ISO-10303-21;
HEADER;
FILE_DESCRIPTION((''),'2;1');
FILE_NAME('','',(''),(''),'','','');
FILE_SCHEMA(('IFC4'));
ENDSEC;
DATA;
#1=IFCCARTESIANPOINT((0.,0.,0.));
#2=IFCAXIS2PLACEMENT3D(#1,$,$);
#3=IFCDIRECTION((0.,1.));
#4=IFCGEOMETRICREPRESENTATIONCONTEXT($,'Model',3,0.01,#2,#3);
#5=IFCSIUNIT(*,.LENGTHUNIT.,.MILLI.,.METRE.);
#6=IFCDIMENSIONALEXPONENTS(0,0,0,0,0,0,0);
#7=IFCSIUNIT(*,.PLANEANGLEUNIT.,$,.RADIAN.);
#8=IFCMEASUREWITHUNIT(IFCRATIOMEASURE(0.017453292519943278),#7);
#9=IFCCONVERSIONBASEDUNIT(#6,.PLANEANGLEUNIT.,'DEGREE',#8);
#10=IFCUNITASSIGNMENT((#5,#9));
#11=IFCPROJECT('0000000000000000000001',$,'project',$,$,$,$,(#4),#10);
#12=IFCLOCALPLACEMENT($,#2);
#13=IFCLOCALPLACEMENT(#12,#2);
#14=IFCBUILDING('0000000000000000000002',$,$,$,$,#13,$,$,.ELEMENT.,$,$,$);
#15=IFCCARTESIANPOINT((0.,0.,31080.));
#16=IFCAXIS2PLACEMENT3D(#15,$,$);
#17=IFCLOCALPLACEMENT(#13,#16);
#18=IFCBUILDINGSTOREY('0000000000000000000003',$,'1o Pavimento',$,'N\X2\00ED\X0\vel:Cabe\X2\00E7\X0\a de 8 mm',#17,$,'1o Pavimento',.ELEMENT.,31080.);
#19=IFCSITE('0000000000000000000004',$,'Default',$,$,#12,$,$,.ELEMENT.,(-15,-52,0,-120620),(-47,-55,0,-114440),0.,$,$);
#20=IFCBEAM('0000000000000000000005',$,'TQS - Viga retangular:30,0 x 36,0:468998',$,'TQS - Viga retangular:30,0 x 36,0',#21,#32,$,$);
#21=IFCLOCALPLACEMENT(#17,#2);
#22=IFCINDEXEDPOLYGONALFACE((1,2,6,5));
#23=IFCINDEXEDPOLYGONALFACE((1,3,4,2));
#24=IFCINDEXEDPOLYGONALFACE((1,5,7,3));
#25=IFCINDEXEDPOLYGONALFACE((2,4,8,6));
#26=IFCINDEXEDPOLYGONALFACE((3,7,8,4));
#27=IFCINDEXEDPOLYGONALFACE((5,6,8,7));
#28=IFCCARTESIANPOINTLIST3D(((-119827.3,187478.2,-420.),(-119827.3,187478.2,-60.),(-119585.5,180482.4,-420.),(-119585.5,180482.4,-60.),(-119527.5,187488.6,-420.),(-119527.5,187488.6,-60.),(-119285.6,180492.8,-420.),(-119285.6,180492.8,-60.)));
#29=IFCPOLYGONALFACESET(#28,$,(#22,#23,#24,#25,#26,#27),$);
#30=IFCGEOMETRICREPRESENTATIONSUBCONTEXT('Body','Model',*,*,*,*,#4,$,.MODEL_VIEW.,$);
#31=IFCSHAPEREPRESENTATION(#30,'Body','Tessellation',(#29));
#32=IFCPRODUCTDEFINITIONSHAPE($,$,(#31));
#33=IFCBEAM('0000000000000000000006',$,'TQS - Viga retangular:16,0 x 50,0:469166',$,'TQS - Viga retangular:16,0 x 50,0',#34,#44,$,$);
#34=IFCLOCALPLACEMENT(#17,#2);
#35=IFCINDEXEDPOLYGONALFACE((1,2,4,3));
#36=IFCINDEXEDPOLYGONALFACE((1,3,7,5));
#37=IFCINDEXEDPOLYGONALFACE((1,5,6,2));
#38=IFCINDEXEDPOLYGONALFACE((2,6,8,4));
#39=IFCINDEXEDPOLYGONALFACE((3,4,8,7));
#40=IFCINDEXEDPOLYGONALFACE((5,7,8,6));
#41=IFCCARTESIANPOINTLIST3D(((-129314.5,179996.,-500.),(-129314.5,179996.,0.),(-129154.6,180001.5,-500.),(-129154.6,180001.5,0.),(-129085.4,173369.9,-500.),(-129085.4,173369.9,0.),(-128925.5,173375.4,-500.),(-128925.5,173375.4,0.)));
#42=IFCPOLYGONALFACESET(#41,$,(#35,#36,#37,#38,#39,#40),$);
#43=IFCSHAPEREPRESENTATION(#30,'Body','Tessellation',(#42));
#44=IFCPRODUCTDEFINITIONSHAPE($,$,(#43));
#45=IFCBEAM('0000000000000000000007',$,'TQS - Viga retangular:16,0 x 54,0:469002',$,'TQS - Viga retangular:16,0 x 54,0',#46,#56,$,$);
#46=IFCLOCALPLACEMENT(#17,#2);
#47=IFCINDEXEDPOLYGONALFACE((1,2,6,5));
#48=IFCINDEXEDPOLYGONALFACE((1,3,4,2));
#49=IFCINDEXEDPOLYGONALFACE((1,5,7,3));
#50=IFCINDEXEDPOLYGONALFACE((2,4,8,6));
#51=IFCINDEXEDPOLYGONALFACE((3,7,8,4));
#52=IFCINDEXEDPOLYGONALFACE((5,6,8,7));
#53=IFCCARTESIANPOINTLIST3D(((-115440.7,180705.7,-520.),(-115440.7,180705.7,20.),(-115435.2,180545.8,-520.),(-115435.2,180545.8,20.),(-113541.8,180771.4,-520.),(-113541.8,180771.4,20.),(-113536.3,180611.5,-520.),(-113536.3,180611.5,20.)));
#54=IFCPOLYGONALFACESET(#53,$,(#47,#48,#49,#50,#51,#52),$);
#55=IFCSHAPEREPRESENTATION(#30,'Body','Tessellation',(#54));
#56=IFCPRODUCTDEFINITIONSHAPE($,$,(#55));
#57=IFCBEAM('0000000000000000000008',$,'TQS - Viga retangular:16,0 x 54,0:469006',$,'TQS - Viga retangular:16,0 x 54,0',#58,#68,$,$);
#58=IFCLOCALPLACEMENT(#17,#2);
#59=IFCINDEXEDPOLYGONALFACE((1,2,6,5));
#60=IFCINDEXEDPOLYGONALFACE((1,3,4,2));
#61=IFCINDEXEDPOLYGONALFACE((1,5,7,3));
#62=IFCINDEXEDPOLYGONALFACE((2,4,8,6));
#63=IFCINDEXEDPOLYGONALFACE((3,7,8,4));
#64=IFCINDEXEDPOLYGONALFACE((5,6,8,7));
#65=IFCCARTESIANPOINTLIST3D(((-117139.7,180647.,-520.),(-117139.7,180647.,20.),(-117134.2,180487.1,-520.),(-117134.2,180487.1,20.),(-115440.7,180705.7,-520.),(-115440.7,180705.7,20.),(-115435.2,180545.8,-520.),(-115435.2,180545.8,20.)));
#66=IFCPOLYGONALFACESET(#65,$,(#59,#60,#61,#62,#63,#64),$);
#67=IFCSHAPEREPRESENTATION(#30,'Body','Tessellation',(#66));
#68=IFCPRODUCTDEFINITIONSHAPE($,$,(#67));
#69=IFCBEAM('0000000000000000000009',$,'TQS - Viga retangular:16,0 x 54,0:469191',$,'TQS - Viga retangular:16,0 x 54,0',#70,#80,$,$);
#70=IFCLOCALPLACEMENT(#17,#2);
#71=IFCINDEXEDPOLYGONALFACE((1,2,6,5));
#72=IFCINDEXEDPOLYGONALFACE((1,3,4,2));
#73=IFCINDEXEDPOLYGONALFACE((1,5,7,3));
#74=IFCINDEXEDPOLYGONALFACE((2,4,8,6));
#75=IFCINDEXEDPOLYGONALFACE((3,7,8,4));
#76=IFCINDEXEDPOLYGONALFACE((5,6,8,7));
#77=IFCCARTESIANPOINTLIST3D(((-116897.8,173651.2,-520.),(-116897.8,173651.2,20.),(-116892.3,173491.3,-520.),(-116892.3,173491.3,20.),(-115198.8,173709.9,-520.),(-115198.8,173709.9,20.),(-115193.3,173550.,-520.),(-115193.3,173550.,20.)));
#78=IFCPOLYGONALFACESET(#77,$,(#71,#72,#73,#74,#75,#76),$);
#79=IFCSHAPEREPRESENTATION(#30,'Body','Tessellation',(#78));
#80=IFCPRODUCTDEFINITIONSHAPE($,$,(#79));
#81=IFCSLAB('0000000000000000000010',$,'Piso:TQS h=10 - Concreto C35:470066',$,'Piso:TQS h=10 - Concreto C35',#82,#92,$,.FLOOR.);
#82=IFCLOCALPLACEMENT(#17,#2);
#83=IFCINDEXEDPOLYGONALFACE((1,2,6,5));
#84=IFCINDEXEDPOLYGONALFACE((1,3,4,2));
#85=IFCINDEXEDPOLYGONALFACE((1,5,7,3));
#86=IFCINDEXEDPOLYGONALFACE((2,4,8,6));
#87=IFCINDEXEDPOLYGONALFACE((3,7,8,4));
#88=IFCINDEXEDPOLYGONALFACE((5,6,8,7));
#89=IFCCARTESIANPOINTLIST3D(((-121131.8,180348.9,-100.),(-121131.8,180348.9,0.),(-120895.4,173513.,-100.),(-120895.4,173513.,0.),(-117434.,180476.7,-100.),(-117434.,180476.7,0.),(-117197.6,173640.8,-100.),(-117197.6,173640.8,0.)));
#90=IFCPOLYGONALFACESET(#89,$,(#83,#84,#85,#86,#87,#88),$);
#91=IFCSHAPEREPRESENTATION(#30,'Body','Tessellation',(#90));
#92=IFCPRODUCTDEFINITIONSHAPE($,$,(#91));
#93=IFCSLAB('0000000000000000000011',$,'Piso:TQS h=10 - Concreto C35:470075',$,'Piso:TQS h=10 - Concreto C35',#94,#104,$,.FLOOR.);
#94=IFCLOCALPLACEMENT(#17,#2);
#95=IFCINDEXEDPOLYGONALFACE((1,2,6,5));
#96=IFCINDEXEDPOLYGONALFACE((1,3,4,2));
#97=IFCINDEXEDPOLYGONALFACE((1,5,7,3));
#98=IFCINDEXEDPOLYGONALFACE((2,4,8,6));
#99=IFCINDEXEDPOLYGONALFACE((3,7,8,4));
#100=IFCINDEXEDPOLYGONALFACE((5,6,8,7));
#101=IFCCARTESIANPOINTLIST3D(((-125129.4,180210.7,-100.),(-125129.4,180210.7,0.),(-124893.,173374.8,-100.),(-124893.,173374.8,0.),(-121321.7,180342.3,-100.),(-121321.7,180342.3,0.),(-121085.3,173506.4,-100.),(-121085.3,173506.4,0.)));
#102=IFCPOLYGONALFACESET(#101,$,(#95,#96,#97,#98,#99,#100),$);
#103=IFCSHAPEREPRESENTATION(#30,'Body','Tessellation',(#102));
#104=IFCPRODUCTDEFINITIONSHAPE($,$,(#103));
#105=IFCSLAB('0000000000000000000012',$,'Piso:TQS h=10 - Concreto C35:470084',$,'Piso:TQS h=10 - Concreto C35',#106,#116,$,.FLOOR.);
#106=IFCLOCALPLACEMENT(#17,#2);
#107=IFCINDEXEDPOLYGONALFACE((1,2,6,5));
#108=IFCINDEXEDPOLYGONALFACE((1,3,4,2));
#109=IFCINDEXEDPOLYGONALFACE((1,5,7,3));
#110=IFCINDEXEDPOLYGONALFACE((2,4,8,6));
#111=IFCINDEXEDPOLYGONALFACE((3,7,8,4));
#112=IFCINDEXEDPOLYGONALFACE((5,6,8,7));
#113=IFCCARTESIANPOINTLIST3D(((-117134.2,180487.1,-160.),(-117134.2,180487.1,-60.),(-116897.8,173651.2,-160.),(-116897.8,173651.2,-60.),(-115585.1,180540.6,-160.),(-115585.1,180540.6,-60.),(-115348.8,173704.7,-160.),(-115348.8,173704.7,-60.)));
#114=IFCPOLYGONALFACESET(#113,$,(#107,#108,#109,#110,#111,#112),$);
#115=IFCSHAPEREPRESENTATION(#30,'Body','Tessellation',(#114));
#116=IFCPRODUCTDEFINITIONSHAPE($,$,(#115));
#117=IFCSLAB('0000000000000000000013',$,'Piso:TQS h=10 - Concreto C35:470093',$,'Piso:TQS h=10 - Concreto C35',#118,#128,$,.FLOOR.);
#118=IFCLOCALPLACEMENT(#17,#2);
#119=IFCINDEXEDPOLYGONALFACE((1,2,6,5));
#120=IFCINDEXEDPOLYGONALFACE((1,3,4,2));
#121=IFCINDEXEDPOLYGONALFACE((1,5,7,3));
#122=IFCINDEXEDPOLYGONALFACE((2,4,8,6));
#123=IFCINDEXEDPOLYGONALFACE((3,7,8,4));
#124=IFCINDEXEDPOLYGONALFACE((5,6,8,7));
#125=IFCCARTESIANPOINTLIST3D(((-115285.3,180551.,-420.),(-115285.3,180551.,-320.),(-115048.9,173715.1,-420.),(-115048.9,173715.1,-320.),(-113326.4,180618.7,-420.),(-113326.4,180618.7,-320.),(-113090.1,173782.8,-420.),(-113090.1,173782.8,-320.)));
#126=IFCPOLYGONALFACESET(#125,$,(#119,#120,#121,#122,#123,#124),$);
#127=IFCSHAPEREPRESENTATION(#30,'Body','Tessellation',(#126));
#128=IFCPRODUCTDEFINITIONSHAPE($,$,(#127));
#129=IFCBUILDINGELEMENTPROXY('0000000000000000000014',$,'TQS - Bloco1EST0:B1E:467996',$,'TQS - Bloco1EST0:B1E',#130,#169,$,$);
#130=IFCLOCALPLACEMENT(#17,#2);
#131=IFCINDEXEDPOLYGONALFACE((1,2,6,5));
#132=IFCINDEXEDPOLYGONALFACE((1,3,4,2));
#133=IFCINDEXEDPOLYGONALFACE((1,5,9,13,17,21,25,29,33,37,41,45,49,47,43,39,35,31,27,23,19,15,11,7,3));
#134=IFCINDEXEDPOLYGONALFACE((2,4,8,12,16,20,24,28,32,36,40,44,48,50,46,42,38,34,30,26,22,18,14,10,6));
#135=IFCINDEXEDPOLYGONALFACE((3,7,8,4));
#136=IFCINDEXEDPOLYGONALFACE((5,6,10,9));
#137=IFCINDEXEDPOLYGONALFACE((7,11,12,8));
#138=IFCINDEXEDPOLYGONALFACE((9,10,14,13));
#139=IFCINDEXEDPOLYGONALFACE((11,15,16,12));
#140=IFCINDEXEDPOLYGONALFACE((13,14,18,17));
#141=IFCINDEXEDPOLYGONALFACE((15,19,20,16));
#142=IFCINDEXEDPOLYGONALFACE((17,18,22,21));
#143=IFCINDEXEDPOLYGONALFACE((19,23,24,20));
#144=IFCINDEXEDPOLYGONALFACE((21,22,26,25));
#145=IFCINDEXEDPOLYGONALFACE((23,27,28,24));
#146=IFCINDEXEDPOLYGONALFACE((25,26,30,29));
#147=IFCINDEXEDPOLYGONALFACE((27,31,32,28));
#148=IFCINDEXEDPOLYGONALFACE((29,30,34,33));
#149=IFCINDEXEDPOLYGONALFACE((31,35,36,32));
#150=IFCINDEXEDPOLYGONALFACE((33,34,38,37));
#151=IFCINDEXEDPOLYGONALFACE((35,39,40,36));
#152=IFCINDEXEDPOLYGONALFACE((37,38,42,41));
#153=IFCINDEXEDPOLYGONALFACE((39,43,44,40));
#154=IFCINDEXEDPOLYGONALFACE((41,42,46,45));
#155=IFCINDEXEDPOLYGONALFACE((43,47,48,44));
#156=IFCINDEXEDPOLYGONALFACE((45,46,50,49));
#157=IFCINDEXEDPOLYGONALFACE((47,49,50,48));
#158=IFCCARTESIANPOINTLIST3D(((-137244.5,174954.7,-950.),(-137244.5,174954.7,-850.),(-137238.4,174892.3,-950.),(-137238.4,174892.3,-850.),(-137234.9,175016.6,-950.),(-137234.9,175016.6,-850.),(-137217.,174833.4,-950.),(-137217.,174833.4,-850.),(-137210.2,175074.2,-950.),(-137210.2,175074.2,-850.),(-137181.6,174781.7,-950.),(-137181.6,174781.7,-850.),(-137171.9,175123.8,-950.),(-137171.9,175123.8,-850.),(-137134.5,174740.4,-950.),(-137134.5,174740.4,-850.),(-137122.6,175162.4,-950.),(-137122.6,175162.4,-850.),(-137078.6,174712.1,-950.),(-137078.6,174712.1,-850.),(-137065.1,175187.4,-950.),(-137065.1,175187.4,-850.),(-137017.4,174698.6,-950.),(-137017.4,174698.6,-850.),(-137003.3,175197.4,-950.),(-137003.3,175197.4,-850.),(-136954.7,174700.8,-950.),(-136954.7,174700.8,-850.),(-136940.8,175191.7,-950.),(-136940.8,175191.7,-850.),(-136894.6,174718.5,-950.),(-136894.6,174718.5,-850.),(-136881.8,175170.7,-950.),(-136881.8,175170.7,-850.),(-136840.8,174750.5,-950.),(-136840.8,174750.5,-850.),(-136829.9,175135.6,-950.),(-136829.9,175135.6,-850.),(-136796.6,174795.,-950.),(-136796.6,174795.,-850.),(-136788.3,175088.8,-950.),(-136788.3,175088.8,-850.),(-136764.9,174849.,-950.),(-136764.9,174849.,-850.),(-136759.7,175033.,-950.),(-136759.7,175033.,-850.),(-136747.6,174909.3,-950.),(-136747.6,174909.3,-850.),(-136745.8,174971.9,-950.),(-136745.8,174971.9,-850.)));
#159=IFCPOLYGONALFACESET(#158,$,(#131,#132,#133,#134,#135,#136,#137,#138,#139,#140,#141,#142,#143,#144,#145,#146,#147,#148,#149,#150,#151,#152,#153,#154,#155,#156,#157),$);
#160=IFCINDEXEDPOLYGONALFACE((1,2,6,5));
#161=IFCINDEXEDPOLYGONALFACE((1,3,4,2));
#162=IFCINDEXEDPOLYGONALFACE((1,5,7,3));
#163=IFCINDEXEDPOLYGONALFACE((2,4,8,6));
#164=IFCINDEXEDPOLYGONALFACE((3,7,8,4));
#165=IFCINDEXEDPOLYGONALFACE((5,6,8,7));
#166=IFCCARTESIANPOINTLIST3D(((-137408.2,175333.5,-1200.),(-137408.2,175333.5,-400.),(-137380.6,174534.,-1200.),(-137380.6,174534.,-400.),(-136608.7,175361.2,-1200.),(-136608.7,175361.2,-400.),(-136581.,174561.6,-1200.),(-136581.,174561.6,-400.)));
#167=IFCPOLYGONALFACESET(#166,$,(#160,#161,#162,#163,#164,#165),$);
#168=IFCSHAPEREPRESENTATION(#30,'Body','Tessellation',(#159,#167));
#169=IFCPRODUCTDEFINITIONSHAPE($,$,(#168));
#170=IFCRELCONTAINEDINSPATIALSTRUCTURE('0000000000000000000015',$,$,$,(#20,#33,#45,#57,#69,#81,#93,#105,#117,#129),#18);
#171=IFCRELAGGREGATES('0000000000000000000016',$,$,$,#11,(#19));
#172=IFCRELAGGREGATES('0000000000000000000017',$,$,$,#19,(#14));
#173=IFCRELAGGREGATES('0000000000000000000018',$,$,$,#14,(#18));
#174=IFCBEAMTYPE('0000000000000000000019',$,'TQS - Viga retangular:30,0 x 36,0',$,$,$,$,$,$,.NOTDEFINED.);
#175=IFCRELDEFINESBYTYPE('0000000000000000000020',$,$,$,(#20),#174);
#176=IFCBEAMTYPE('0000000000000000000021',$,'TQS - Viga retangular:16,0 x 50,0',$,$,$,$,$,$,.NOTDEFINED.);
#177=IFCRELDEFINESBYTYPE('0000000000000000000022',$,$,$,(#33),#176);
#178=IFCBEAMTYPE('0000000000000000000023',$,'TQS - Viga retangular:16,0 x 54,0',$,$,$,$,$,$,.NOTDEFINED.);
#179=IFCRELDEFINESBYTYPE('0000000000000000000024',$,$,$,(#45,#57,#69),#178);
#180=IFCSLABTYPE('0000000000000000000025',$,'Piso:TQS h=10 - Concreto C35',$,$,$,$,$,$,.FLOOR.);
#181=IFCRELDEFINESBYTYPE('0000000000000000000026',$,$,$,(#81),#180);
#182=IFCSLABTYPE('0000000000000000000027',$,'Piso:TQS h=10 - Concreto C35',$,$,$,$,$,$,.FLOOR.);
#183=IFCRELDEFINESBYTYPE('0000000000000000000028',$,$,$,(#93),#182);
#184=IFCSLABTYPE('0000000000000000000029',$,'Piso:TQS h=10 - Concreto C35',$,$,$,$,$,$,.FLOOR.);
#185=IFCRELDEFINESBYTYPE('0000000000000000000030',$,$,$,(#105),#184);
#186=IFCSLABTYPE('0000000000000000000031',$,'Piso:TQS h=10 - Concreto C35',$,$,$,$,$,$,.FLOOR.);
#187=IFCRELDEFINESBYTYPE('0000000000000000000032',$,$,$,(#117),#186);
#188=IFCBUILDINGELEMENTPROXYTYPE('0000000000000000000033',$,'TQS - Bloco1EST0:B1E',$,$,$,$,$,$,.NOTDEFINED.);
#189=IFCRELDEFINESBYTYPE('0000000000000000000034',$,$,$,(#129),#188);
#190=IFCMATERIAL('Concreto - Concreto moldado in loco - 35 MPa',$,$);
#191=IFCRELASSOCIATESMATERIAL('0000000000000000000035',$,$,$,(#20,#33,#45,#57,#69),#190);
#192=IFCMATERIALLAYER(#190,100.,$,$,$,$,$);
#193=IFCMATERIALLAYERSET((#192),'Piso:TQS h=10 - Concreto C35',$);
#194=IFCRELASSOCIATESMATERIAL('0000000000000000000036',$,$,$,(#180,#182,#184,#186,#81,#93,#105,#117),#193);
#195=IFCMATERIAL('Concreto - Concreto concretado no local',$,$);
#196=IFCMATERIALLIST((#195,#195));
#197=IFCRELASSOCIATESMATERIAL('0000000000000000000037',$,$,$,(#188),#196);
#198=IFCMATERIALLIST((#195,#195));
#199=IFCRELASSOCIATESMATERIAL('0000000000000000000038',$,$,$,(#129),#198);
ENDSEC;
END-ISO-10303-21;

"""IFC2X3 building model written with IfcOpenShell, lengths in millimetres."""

from ifc_helpers import new_model, entity, si_unit, converted_unit, direction, frame, frame_2d, origin, origin_2d_with_axis, place, context, subcontext, project, spatial, rectangle, circle, extrude, source, transform, mapped, material, material_list, layer, layer_set, layer_usage, type_object, type_shapes, element, save


model = new_model("IFC2X3")

# Units and contexts
model_context = context("Model", 3, precision=0.01, world=origin(), true_north=direction((0.0, 1.0)))
body_context = subcontext(model_context, "Body", "Model", "MODEL_VIEW")
ifc_project = project(units=[si_unit("LENGTHUNIT", "METRE", prefix="MILLI"), converted_unit("PLANEANGLEUNIT", "DEGREE", entity("IfcRatioMeasure", 0.017453292519943278), si_unit("PLANEANGLEUNIT", "RADIAN"), dimensions=[0, 0, 0, 0, 0, 0, 0])], contexts=[model_context])

# Site, building, storey
site_placement = place(None, origin())
site = spatial("IfcSite", under=ifc_project, at=site_placement, Name="Default", CompositionType="ELEMENT", RefLatitude=(-15, -52, 0, -120620), RefLongitude=(-47, -55, 0, -114440), RefElevation=0.0)
building_placement = place(site_placement, origin())
building = spatial("IfcBuilding", under=site, at=building_placement, CompositionType="ELEMENT")
storey_placement = place(building_placement, frame((0.0, 0.0, 31080.0)))
storey = spatial("IfcBuildingStorey", under=building, at=storey_placement, Name="1o Pavimento", ObjectType="Nível:Cabeça de 8 mm", LongName="1o Pavimento", CompositionType="ELEMENT", Elevation=31080.0)

# Beams
ifc_material_1 = material(Name="Concreto - Concreto moldado in loco - 35 MPa")
beam_type_1 = type_object("IfcBeamType", Name="TQS - Viga retangular:30,0 x 36,0", PredefinedType="NOTDEFINED")
beam_1_placement = place(storey_placement, frame((-119435.5, 180487.6, -60.0), z_axis=(0.0, 0.0, 1.0), x_axis=(-0.034551, 0.999403, 0.0)))
element("IfcBeam", 1, at=beam_1_placement, inside=storey, type_object=beam_type_1, material=ifc_material_1, Name="TQS - Viga retangular:30,0 x 36,0:468998", ObjectType="TQS - Viga retangular:30,0 x 36,0", context=body_context, shape_type="SweptSolid", body=[
    extrude(rectangle(XDim=360.0, YDim=300.0, at=frame_2d((0.0, 0.0), x_axis=(1.0, 0.0))), frame((0.0, 0.0, -180.0), z_axis=(1.0, 0.0, 0.0), x_axis=(0.0, 0.0, -1.0)), (0.0, 0.0, 1.0), 7000.0),
])
beam_type_2 = type_object("IfcBeamType", Name="TQS - Viga retangular:16,0 x 50,0", PredefinedType="NOTDEFINED")
beam_2_placement = place(storey_placement, frame((-129005.4, 173372.7, 0.0), z_axis=(0.0, 0.0, 1.0), x_axis=(-0.034551, 0.999403, 0.0)))
element("IfcBeam", 2, at=beam_2_placement, inside=storey, type_object=beam_type_2, material=ifc_material_1, Name="TQS - Viga retangular:16,0 x 50,0:469166", ObjectType="TQS - Viga retangular:16,0 x 50,0", context=body_context, shape_type="SweptSolid", body=[
    extrude(rectangle(XDim=500.0, YDim=160.0, at=frame_2d((0.0, 0.0), x_axis=(1.0, 0.0))), frame((0.0, 0.0, -250.0), z_axis=(1.0, 0.0, 0.0), x_axis=(0.0, 0.0, -1.0)), (0.0, 0.0, 1.0), 6630.0),
])
beam_type_3 = type_object("IfcBeamType", Name="TQS - Viga retangular:16,0 x 54,0", PredefinedType="NOTDEFINED")
beam_3_placement = place(storey_placement, frame((-113539.1, 180691.4, 20.0), z_axis=(0.0, 0.0, 1.0), x_axis=(-0.999403, -0.034551, 0.0)))
element("IfcBeam", 3, at=beam_3_placement, inside=storey, type_object=beam_type_3, material=ifc_material_1, Name="TQS - Viga retangular:16,0 x 54,0:469002", ObjectType="TQS - Viga retangular:16,0 x 54,0", context=body_context, shape_type="SweptSolid", body=[
    extrude(rectangle(XDim=540.0, YDim=160.0, at=origin_2d_with_axis()), frame((0.0, 0.0, -270.0), z_axis=(1.0, 0.0, 0.0), x_axis=(0.0, 0.0, -1.0)), (0.0, 0.0, 1.0), 1900.0),
])
beam_4_placement = place(storey_placement, frame((-115437.9, 180625.8, 20.0), z_axis=(0.0, 0.0, 1.0), x_axis=(-0.999403, -0.034551, 0.0)))
element("IfcBeam", 4, at=beam_4_placement, inside=storey, type_object=beam_type_3, material=ifc_material_1, Name="TQS - Viga retangular:16,0 x 54,0:469006", ObjectType="TQS - Viga retangular:16,0 x 54,0", context=body_context, shape_type="SweptSolid", body=[
    extrude(rectangle(XDim=540.0, YDim=160.0, at=frame_2d((0.0, 0.0), x_axis=(1.0, 0.0))), frame((0.0, 0.0, -270.0), z_axis=(1.0, 0.0, 0.0), x_axis=(0.0, 0.0, -1.0)), (0.0, 0.0, 1.0), 1700.0),
])
beam_5_placement = place(storey_placement, frame((-115196.1, 173630.0, 20.0), z_axis=(0.0, 0.0, 1.0), x_axis=(-0.999403, -0.034551, 0.0)))
element("IfcBeam", 5, at=beam_5_placement, inside=storey, type_object=beam_type_3, material=ifc_material_1, Name="TQS - Viga retangular:16,0 x 54,0:469191", ObjectType="TQS - Viga retangular:16,0 x 54,0", context=body_context, shape_type="SweptSolid", body=[
    extrude(rectangle(XDim=540.0, YDim=160.0, at=frame_2d((0.0, 0.0), x_axis=(1.0, 0.0))), frame((0.0, 0.0, -270.0), z_axis=(1.0, 0.0, 0.0), x_axis=(0.0, 0.0, -1.0)), (0.0, 0.0, 1.0), 1700.0),
])

# Slabs
ifc_layer = layer(ifc_material_1, 100.0)
ifc_layer_set = layer_set([ifc_layer], Name="Piso:TQS h=10 - Concreto C35")
ifc_layer_usage_1 = layer_usage(ifc_layer_set, "AXIS3", "POSITIVE", 0.0)
slab_type_1 = type_object("IfcSlabType", Name="Piso:TQS h=10 - Concreto C35", PredefinedType="FLOOR", material=ifc_layer_set)
slab_1_placement = place(storey_placement, origin())
element("IfcSlab", 6, at=slab_1_placement, inside=storey, type_object=slab_type_1, material=ifc_layer_usage_1, Name="Piso:TQS h=10 - Concreto C35:470066", ObjectType="Piso:TQS h=10 - Concreto C35", PredefinedType="FLOOR", context=body_context, shape_type="SweptSolid", body=[
    extrude(rectangle(XDim=6840.0, YDim=3700.0, at=frame_2d((0.0, 0.0), x_axis=(1.0, 0.0))), frame((-119164.7, 176994.8, 0.0), z_axis=(0.0, 0.0, -1.0), x_axis=(0.034551, -0.999403, 0.0)), (0.0, 0.0, 1.0), 100.0),
])
ifc_layer_usage_2 = layer_usage(ifc_layer_set, "AXIS3", "POSITIVE", 0.0)
slab_type_2 = type_object("IfcSlabType", Name="Piso:TQS h=10 - Concreto C35", PredefinedType="FLOOR", material=ifc_layer_set)
slab_2_placement = place(storey_placement, origin())
element("IfcSlab", 7, at=slab_2_placement, inside=storey, type_object=slab_type_2, material=ifc_layer_usage_2, Name="Piso:TQS h=10 - Concreto C35:470075", ObjectType="Piso:TQS h=10 - Concreto C35", PredefinedType="FLOOR", context=body_context, shape_type="SweptSolid", body=[
    extrude(rectangle(XDim=6840.0, YDim=3810.0, at=frame_2d((0.0, 0.0), x_axis=(1.0, 0.0))), frame((-123107.4, 176858.5, 0.0), z_axis=(0.0, 0.0, -1.0), x_axis=(0.034551, -0.999403, 0.0)), (0.0, 0.0, 1.0), 100.0),
])
ifc_layer_usage_3 = layer_usage(ifc_layer_set, "AXIS3", "POSITIVE", 0.0)
slab_type_3 = type_object("IfcSlabType", Name="Piso:TQS h=10 - Concreto C35", PredefinedType="FLOOR", material=ifc_layer_set)
slab_3_placement = place(storey_placement, origin())
element("IfcSlab", 8, at=slab_3_placement, inside=storey, type_object=slab_type_3, material=ifc_layer_usage_3, Name="Piso:TQS h=10 - Concreto C35:470084", ObjectType="Piso:TQS h=10 - Concreto C35", PredefinedType="FLOOR", context=body_context, shape_type="SweptSolid", body=[
    extrude(rectangle(XDim=1550.0, YDim=6840.0, at=frame_2d((0.0, 0.0), x_axis=(1.0, 0.0))), frame((-116241.5, 177095.9, -60.0), z_axis=(0.0, 0.0, -1.0), x_axis=(0.999403, 0.034551, 0.0)), (0.0, 0.0, 1.0), 100.0),
])
ifc_layer_usage_4 = layer_usage(ifc_layer_set, "AXIS3", "POSITIVE", 0.0)
slab_type_4 = type_object("IfcSlabType", Name="Piso:TQS h=10 - Concreto C35", PredefinedType="FLOOR", material=ifc_layer_set)
slab_4_placement = place(storey_placement, origin())
element("IfcSlab", 9, at=slab_4_placement, inside=storey, type_object=slab_type_4, material=ifc_layer_usage_4, Name="Piso:TQS h=10 - Concreto C35:470093", ObjectType="Piso:TQS h=10 - Concreto C35", PredefinedType="FLOOR", context=body_context, shape_type="SweptSolid", body=[
    extrude(rectangle(XDim=6840.0, YDim=1960.0, at=frame_2d((0.0, 0.0), x_axis=(1.0, 0.0))), frame((-114187.7, 177166.9, -320.0), z_axis=(0.0, 0.0, -1.0), x_axis=(0.034551, -0.999403, 0.0)), (0.0, 0.0, 1.0), 100.0),
])

# Building element proxy
ifc_material_2 = material(Name="Concreto - Concreto concretado no local")
ifc_material_list_1 = material_list([ifc_material_2, ifc_material_2])
ifc_material_list_2 = material_list([ifc_material_2, ifc_material_2])
building_element_proxy_type_1 = type_object("IfcBuildingElementProxyType", Name="TQS - Bloco1EST0:B1E", PredefinedType="NOTDEFINED", material=ifc_material_list_2)
shared_shape_1 = source(origin(), body_context, "Body", "SweptSolid", [
    extrude(circle(Radius=250.0, at=frame_2d((0.0, 0.0), x_axis=(1.0, 0.0))), frame((0.0, 0.0, -550.0)), (0.0, 0.0, 1.0), 100.0),
    extrude(rectangle(XDim=800.0, YDim=800.0, at=origin_2d_with_axis()), frame((0.0, 0.0, -800.0), z_axis=(0.0, 0.0, 1.0), x_axis=(-1.0, 0.0, 0.0)), (0.0, 0.0, 1.0), 800.0),
])
type_shapes(building_element_proxy_type_1, [shared_shape_1])
proxy_1_placement = place(storey_placement, frame((-136994.6, 174947.6, -400.0), z_axis=(0.0, 0.0, 1.0), x_axis=(-0.034551, 0.999403, 0.0)))
element("IfcBuildingElementProxy", 10, at=proxy_1_placement, inside=storey, type_object=building_element_proxy_type_1, material=ifc_material_list_1, Name="TQS - Bloco1EST0:B1E:467996", ObjectType="TQS - Bloco1EST0:B1E", context=body_context, shape_type="MappedRepresentation", body=[
    mapped(shared_shape_1, transform((0.0, 0.0, 0.0), scale=1.0)),
])

save(model, "model.ifc")
